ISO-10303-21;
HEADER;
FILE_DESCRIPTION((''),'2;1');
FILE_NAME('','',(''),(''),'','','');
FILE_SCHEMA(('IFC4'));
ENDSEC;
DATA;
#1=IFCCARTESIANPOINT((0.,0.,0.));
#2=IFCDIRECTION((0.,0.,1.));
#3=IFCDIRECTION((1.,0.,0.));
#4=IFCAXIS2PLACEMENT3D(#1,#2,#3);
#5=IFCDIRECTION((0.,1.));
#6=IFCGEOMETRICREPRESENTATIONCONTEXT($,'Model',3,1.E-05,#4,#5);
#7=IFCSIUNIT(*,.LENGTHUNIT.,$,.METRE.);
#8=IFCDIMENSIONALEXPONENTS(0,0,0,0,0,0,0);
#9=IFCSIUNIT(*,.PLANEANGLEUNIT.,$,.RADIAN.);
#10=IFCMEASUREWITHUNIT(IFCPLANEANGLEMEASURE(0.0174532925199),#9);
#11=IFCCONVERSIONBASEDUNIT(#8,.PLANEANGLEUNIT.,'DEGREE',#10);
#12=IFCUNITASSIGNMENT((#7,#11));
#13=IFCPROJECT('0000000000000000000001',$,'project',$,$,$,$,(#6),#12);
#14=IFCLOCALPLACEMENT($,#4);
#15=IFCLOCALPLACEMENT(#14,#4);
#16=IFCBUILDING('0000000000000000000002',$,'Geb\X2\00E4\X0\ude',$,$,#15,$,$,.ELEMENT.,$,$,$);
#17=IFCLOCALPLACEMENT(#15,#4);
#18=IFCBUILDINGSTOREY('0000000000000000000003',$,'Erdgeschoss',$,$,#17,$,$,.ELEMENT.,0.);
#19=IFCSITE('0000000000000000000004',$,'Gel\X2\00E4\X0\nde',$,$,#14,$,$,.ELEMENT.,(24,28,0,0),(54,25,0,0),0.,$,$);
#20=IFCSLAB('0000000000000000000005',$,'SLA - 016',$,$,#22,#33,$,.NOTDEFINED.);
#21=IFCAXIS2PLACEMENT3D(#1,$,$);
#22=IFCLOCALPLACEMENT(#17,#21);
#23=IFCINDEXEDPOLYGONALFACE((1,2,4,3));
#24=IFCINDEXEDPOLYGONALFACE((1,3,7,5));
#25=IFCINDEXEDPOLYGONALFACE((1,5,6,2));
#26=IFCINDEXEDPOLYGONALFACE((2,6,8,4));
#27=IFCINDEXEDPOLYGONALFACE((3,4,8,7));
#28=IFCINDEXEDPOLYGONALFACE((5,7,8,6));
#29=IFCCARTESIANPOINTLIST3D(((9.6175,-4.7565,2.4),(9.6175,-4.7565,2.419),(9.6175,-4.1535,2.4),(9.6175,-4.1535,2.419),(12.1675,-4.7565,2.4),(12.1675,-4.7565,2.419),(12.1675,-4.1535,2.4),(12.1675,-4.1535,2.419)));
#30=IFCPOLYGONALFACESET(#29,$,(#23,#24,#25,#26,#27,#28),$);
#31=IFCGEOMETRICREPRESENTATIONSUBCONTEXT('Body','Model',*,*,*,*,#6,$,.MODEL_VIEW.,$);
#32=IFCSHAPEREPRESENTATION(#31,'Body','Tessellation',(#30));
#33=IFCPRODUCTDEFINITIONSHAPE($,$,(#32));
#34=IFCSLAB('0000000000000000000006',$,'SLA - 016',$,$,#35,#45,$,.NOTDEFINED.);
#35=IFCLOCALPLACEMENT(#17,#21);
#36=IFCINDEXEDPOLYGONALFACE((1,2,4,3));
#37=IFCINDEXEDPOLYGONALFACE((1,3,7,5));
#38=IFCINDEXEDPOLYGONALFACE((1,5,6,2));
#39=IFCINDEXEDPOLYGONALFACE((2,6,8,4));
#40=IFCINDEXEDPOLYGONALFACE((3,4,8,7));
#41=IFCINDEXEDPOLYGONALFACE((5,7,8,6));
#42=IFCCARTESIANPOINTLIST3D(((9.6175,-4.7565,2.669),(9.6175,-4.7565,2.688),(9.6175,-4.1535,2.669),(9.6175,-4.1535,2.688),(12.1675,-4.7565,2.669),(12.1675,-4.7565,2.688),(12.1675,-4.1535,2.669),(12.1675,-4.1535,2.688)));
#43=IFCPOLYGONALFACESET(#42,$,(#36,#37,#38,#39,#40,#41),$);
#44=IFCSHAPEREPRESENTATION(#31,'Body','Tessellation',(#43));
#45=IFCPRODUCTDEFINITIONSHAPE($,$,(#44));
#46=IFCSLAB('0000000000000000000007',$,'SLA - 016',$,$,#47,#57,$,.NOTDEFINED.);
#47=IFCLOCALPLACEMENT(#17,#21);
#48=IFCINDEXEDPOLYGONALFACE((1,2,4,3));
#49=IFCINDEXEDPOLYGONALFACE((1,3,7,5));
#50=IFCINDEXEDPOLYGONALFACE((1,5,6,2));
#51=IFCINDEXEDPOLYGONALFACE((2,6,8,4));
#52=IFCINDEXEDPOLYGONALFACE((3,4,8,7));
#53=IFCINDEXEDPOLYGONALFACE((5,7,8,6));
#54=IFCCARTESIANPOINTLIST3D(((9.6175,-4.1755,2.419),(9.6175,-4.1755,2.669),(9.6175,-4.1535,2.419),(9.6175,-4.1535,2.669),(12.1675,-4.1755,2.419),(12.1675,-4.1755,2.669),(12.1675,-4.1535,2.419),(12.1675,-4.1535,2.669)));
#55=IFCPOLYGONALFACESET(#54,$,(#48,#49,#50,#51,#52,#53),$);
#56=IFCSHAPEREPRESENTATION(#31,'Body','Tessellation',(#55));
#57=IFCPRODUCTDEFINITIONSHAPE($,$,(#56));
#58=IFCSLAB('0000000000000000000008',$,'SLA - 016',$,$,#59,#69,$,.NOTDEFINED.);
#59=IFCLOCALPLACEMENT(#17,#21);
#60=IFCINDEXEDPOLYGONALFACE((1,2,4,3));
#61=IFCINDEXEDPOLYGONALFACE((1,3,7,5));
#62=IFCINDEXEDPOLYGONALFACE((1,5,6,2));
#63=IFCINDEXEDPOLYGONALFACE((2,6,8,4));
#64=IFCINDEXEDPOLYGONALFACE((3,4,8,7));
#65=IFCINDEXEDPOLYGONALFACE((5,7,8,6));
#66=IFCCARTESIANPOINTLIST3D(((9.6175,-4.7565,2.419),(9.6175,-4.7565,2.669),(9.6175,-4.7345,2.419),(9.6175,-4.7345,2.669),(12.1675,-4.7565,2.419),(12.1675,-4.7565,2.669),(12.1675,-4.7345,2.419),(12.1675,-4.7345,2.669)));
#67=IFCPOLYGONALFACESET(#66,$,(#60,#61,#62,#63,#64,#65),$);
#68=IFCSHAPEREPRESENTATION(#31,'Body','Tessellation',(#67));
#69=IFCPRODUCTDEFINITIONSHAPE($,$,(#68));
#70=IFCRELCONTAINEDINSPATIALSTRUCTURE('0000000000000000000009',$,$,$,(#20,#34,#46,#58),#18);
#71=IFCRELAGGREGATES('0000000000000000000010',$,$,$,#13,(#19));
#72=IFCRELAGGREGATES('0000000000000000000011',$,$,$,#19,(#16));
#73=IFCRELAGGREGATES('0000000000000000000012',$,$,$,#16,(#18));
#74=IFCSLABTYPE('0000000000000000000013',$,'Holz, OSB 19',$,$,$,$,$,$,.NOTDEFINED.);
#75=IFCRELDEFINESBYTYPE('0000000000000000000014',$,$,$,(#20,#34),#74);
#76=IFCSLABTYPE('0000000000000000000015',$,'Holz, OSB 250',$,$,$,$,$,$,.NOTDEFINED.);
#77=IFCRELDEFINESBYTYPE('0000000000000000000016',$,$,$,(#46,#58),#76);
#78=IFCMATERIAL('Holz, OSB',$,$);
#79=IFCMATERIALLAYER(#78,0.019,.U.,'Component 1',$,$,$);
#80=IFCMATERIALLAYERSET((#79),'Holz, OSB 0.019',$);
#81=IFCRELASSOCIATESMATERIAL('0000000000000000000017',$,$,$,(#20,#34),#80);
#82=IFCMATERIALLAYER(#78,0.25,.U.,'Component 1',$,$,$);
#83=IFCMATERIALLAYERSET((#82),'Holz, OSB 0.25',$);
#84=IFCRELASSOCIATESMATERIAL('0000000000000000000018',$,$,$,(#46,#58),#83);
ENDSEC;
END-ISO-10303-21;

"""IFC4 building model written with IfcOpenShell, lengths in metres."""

from ifc_helpers import new_model, entity, si_unit, converted_unit, direction, frame, origin_with_axes, place, context, subcontext, project, spatial, line, indexed_curve, outline, extrude, material, layer, layer_set, layer_usage, type_object, element, save


model = new_model("IFC4")

# Units and contexts
model_context = context("Model", 3, precision=1e-05, world=origin_with_axes(), true_north=direction((0.0, 1.0)))
body_context = subcontext(model_context, "Body", "Model", "MODEL_VIEW")
ifc_project = project(units=[si_unit("LENGTHUNIT", "METRE"), converted_unit("PLANEANGLEUNIT", "DEGREE", entity("IfcPlaneAngleMeasure", 0.0174532925199), si_unit("PLANEANGLEUNIT", "RADIAN"), dimensions=[0, 0, 0, 0, 0, 0, 0])], contexts=[model_context])

# Site, building, storey
site_placement = place(None, origin_with_axes())
site = spatial("IfcSite", under=ifc_project, at=site_placement, Name="Gelände", CompositionType="ELEMENT", RefLatitude=(24, 28, 0, 0), RefLongitude=(54, 25, 0, 0), RefElevation=0.0)
building_placement = place(site_placement, origin_with_axes())
building = spatial("IfcBuilding", under=site, at=building_placement, Name="Gebäude", CompositionType="ELEMENT")
storey_placement = place(building_placement, origin_with_axes())
storey = spatial("IfcBuildingStorey", under=building, at=storey_placement, Name="Erdgeschoss", CompositionType="ELEMENT", Elevation=0.0)

# Slabs
ifc_material_1 = material(Name="Holz, OSB")
ifc_layer_1 = layer(ifc_material_1, 0.019, ventilated="UNKNOWN", Name="Component 1")
ifc_layer_set_1 = layer_set([ifc_layer_1], Name="Holz, OSB 0.019")
ifc_layer_usage_1 = layer_usage(ifc_layer_set_1, "AXIS3", "NEGATIVE", 0.019)
slab_type_1 = type_object("IfcSlabType", Name="Holz, OSB 19", PredefinedType="NOTDEFINED")
slab_1_placement = place(storey_placement, frame((9.6175, -4.1535, 2.419), z_axis=(0.0, 0.0, 1.0), x_axis=(1.0, 0.0, 0.0)))
element("IfcSlab", 1, at=slab_1_placement, inside=storey, type_object=slab_type_1, material=ifc_layer_usage_1, Name="SLA - 016", PredefinedType="NOTDEFINED", context=body_context, shape_type="SweptSolid", body=[
    extrude(outline(indexed_curve([(0.0, 0.0), (0.0, -0.603), (2.55, -0.603), (2.55, 0.0)], segments=[line(1, 2, 3, 4, 1)])), frame((0.0, 0.0, -0.019), z_axis=(0.0, 0.0, 1.0), x_axis=(1.0, 0.0, 0.0)), (0.0, 0.0, 1.0), 0.019),
])
ifc_layer_usage_2 = layer_usage(ifc_layer_set_1, "AXIS3", "NEGATIVE", 0.019)
slab_2_placement = place(storey_placement, frame((9.6175, -4.1535, 2.688), z_axis=(0.0, 0.0, 1.0), x_axis=(1.0, 0.0, 0.0)))
element("IfcSlab", 2, at=slab_2_placement, inside=storey, type_object=slab_type_1, material=ifc_layer_usage_2, Name="SLA - 016", PredefinedType="NOTDEFINED", context=body_context, shape_type="SweptSolid", body=[
    extrude(outline(indexed_curve([(0.0, 0.0), (0.0, -0.603), (2.55, -0.603), (2.55, 0.0)], segments=[line(1, 2, 3, 4, 1)])), frame((0.0, 0.0, -0.019), z_axis=(0.0, 0.0, 1.0), x_axis=(1.0, 0.0, 0.0)), (0.0, 0.0, 1.0), 0.019),
])
ifc_layer_2 = layer(ifc_material_1, 0.25, ventilated="UNKNOWN", Name="Component 1")
ifc_layer_set_2 = layer_set([ifc_layer_2], Name="Holz, OSB 0.25")
ifc_layer_usage_3 = layer_usage(ifc_layer_set_2, "AXIS3", "NEGATIVE", 0.25)
slab_type_2 = type_object("IfcSlabType", Name="Holz, OSB 250", PredefinedType="NOTDEFINED")
slab_3_placement = place(storey_placement, frame((9.6175, -4.1535, 2.669), z_axis=(0.0, 0.0, 1.0), x_axis=(1.0, 0.0, 0.0)))
element("IfcSlab", 3, at=slab_3_placement, inside=storey, type_object=slab_type_2, material=ifc_layer_usage_3, Name="SLA - 016", PredefinedType="NOTDEFINED", context=body_context, shape_type="SweptSolid", body=[
    extrude(outline(indexed_curve([(0.0, 0.0), (0.0, -0.022), (2.55, -0.022), (2.55, 0.0)], segments=[line(1, 2, 3, 4, 1)])), frame((0.0, 0.0, -0.25), z_axis=(0.0, 0.0, 1.0), x_axis=(1.0, 0.0, 0.0)), (0.0, 0.0, 1.0), 0.25),
])
ifc_layer_usage_4 = layer_usage(ifc_layer_set_2, "AXIS3", "NEGATIVE", 0.25)
slab_4_placement = place(storey_placement, frame((9.6175, -4.7345, 2.669), z_axis=(0.0, 0.0, 1.0), x_axis=(1.0, 0.0, 0.0)))
element("IfcSlab", 4, at=slab_4_placement, inside=storey, type_object=slab_type_2, material=ifc_layer_usage_4, Name="SLA - 016", PredefinedType="NOTDEFINED", context=body_context, shape_type="SweptSolid", body=[
    extrude(outline(indexed_curve([(0.0, 0.0), (0.0, -0.022), (2.55, -0.022), (2.55, 0.0)], segments=[line(1, 2, 3, 4, 1)])), frame((0.0, 0.0, -0.25), z_axis=(0.0, 0.0, 1.0), x_axis=(1.0, 0.0, 0.0)), (0.0, 0.0, 1.0), 0.25),
])

save(model, "model.ifc")
